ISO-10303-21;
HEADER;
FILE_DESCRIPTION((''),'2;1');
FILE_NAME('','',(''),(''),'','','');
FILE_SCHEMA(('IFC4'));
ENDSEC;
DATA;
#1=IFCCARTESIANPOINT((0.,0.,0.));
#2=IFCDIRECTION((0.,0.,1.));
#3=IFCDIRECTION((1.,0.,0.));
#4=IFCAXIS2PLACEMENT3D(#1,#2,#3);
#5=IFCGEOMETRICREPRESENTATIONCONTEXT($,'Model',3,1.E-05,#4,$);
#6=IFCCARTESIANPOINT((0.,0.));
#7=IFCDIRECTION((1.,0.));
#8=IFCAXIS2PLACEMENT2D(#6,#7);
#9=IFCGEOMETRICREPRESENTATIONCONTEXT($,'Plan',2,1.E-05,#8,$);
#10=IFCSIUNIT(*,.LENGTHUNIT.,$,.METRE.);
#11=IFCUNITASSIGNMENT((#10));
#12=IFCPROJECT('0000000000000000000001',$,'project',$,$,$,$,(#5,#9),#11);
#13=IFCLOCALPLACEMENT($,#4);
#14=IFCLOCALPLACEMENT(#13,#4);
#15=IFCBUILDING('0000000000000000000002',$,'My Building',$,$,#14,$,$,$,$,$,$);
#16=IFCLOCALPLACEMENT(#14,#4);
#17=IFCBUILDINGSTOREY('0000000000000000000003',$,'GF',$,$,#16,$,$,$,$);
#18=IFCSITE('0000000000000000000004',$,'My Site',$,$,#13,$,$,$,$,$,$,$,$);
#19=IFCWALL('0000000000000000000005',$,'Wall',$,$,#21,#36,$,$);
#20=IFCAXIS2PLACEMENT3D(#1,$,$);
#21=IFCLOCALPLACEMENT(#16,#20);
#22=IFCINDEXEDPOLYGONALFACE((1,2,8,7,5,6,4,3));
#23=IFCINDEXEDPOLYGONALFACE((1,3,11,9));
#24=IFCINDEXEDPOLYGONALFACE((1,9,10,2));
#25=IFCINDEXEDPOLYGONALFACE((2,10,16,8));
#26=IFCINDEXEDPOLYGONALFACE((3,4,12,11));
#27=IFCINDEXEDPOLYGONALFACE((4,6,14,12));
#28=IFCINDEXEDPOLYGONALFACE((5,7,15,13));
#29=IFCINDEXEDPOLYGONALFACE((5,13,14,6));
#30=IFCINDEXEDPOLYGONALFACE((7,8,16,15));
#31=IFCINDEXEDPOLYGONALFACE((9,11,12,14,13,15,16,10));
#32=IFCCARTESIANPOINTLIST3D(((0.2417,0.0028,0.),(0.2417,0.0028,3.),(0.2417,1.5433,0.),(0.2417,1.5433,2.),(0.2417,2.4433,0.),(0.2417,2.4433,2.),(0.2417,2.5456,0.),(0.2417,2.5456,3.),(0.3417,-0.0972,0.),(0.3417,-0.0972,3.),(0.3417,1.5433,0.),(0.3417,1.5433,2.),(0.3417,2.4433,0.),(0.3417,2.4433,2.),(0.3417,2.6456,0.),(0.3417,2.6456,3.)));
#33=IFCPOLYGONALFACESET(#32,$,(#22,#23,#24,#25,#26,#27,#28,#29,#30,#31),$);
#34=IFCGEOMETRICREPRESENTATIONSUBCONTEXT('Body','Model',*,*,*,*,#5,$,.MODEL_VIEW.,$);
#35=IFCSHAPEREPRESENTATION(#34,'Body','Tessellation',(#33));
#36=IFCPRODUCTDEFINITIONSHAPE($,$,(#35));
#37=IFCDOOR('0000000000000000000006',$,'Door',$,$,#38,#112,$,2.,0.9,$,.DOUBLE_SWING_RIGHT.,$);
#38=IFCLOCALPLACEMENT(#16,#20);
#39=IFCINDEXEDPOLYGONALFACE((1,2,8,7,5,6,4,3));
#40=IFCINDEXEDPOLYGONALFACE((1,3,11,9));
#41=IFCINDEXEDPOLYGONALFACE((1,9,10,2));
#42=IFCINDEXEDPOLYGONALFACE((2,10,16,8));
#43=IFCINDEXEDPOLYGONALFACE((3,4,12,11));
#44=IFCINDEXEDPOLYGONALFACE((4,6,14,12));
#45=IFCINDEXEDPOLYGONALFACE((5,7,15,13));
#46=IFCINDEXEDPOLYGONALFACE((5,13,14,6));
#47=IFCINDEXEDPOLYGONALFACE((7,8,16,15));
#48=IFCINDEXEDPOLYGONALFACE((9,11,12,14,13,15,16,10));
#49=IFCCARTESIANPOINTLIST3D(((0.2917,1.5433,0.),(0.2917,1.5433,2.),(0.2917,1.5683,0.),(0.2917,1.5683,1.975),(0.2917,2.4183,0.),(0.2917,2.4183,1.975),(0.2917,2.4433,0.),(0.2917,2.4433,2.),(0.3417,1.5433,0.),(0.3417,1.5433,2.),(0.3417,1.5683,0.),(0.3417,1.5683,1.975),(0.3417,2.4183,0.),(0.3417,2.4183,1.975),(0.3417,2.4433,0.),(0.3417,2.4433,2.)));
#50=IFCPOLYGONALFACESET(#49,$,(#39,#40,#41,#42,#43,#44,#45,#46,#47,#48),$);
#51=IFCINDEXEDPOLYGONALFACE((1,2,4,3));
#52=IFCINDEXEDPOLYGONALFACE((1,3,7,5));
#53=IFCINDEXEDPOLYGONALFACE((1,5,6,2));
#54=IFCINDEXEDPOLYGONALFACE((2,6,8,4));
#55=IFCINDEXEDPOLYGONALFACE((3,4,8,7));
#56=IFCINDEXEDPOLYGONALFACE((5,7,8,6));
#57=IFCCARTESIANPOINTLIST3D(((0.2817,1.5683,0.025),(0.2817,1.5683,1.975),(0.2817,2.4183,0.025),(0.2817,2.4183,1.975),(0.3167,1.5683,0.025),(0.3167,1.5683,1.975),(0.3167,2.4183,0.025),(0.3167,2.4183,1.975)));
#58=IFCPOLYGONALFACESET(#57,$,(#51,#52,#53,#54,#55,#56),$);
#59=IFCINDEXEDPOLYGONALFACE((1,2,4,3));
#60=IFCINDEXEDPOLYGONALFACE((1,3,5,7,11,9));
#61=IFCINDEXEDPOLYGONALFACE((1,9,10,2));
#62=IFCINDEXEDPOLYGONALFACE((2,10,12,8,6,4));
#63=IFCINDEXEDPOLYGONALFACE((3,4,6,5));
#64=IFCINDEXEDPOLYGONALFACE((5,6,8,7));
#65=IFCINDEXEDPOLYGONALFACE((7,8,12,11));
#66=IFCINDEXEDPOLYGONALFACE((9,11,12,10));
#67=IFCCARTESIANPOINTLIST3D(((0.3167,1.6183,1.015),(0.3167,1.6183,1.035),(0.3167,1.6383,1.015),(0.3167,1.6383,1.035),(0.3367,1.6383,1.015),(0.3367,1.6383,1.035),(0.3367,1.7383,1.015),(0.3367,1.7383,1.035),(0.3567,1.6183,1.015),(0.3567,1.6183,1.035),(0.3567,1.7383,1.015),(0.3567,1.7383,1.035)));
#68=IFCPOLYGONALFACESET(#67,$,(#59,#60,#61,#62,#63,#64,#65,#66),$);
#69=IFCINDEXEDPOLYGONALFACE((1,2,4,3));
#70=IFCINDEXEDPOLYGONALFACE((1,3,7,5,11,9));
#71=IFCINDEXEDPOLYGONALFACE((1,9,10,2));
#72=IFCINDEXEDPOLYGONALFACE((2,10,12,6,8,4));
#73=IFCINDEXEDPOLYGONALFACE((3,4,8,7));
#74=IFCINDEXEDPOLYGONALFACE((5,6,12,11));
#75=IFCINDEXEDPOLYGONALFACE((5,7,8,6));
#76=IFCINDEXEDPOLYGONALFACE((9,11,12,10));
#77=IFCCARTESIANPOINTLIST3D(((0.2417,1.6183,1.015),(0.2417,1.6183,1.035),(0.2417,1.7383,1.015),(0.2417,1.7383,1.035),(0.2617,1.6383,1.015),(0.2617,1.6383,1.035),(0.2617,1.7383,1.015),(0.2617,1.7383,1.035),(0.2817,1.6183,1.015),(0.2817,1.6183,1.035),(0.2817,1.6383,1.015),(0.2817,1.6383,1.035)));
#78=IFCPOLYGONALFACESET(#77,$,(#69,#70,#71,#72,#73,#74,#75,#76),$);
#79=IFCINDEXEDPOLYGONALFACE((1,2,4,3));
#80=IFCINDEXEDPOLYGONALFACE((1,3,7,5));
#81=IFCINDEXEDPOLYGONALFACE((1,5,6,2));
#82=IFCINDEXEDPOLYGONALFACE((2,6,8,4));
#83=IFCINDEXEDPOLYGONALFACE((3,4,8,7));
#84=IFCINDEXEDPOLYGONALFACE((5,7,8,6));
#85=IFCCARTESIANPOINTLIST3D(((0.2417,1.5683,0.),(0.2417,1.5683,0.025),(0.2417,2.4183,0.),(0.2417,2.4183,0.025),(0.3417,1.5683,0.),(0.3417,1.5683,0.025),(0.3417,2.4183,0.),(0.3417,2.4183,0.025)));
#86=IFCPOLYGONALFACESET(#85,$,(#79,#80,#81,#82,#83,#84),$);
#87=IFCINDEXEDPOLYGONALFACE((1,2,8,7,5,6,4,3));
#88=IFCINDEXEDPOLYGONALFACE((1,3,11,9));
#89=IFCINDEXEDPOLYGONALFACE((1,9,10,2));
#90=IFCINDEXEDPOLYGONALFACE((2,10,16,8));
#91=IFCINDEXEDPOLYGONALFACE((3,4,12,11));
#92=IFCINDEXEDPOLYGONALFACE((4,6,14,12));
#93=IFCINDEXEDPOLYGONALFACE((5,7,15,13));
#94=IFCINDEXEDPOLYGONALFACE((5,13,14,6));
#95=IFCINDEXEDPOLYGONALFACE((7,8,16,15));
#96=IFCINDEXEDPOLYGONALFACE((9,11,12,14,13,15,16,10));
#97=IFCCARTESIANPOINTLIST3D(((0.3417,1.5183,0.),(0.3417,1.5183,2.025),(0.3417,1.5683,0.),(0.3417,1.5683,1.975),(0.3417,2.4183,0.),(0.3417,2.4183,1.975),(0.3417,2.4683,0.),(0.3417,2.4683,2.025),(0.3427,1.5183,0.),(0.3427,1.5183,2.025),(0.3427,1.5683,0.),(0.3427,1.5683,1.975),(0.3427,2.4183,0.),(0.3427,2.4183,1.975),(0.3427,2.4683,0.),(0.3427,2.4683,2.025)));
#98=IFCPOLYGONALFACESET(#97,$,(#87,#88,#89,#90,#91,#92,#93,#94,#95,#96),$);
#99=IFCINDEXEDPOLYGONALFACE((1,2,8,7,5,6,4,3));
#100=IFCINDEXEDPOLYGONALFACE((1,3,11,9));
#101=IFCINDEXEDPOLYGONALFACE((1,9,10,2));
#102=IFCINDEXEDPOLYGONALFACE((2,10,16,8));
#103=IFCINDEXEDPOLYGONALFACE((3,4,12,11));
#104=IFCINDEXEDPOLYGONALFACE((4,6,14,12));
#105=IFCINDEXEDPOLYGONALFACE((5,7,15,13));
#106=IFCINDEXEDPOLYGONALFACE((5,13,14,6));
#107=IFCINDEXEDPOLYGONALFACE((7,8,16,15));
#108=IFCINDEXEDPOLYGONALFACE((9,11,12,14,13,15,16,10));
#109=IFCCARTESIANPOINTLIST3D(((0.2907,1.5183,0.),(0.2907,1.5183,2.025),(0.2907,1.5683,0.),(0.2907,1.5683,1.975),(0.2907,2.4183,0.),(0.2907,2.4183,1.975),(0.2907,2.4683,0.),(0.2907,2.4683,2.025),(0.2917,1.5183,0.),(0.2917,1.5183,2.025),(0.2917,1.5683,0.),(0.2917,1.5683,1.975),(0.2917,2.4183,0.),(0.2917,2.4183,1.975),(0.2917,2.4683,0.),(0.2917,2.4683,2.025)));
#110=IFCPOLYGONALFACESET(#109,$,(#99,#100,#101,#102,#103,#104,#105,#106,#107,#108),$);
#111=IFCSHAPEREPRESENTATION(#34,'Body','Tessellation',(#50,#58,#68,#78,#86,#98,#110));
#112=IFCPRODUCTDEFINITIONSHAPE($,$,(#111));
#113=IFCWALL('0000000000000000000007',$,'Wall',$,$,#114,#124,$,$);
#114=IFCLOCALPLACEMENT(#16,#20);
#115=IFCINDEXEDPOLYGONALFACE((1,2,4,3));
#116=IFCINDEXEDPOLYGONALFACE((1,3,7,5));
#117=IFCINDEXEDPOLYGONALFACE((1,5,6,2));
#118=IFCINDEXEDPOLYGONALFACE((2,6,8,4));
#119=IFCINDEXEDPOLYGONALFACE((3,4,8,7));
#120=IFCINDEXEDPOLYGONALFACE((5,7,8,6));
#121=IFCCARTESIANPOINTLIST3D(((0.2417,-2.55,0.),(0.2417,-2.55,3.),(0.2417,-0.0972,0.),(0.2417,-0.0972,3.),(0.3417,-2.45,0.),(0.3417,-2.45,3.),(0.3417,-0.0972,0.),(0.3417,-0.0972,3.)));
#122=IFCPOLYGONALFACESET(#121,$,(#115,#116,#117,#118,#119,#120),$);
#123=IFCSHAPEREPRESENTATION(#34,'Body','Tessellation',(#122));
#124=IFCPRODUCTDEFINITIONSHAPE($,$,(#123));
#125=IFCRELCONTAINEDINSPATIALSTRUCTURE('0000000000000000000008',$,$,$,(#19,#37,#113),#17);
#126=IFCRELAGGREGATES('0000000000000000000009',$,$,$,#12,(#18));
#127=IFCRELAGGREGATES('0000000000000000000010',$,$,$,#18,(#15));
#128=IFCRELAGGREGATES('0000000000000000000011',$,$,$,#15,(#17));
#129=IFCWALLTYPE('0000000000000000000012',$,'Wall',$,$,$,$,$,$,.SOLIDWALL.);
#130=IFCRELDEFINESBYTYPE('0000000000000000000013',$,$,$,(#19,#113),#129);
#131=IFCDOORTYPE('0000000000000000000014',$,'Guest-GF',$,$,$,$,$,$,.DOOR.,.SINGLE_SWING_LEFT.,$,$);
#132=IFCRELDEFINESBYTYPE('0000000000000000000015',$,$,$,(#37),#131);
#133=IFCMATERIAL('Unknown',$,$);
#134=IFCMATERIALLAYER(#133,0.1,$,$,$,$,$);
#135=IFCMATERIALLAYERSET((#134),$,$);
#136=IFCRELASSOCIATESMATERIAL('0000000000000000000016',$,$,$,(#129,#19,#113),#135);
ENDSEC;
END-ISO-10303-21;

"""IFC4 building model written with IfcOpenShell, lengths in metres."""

from ifc_helpers import new_model, entity, si_unit, frame, origin_with_axes, origin_2d_with_axis, place, context, subcontext, project, spatial, line, indexed_curve, outline, extrude, shape, source, transform, mapped, material, layer, layer_set, layer_usage, type_object, type_shapes, element, fill, save


model = new_model("IFC4")

# Units and contexts
model_context = context("Model", 3, precision=1e-05, world=origin_with_axes())
plan_context = context("Plan", 2, precision=1e-05, world=origin_2d_with_axis())
body_context_1 = subcontext(model_context, "Body", "Model", "MODEL_VIEW")
body_context_2 = subcontext(plan_context, "Body", "Plan", "PLAN_VIEW")
ifc_project = project(units=[si_unit("LENGTHUNIT", "METRE")], contexts=[model_context, plan_context])

# Site, building, storey
site_placement = place(None, origin_with_axes())
site = spatial("IfcSite", under=ifc_project, at=site_placement, Name="My Site")
building_placement = place(site_placement, origin_with_axes())
building = spatial("IfcBuilding", under=site, at=building_placement, Name="My Building")
storey_placement = place(building_placement, origin_with_axes())
storey = spatial("IfcBuildingStorey", under=building, at=storey_placement, Name="GF")

# Shared definitions
ifc_material_1 = material(Name="Unknown")

# Shared definitions
ifc_layer_1 = layer(ifc_material_1, 0.1)
ifc_layer_set_1 = layer_set([ifc_layer_1])
wall_type = type_object("IfcWallType", Name="Wall", PredefinedType="SOLIDWALL", material=ifc_layer_set_1)

# Wall, opening, door
ifc_layer_usage_1 = layer_usage(ifc_layer_set_1, "AXIS2", "POSITIVE", 0.0)
wall_1_placement = place(storey_placement, frame((0.3417, -0.0972, 0.0), z_axis=(0.0, 0.0, 1.0), x_axis=(0.0, 1.0, 0.0)))
wall_1 = element("IfcWall", 1, at=wall_1_placement, inside=storey, type_object=wall_type, material=ifc_layer_usage_1, Name="Wall", context=body_context_1, shape_type="SweptSolid", body=[
    extrude(outline(indexed_curve([(0.0, 0.0), (0.1, 0.1), (2.6428, 0.1), (2.7428, 0.0)], segments=[line(1, 2, 3, 4, 1)])), origin_with_axes(), (0.0, 0.0, 1.0), 3.0),
])
shared_shape_1 = source(origin_with_axes(), body_context_1, "Body", "SweptSolid", [
    extrude(outline(indexed_curve([(0.0, 0.0), (0.9, 0.0), (0.9, 2.0), (0.0, 2.0)], segments=[line(1, 2, 3, 4, 1)])), frame((0.0, -0.6, 0.0), z_axis=(0.0, -1.0, 0.0), x_axis=(1.0, 0.0, 0.0)), (0.0, 0.0, -1.0), 1.2),
])
opening_1_placement = place(wall_1_placement, frame((1.6405, 0.0, 0.0), z_axis=(0.0, 0.0, 1.0), x_axis=(1.0, 0.0, 0.0)))
opening_1 = element("IfcOpeningElement", 2, at=opening_1_placement, cuts=wall_1, PredefinedType="OPENING", context=body_context_1, shape_type="MappedRepresentation", body=[
    mapped(shared_shape_1, transform((0.0, 0.0, 0.0), x_axis=(1.0, 0.0, 0.0), y_axis=(0.0, 1.0, 0.0), z_axis=(0.0, 0.0, 1.0), scale=1.0)),
])
door_type_1 = type_object("IfcDoorType", Name="Guest-GF", OperationType="SINGLE_SWING_LEFT", PredefinedType="DOOR")
shared_shape_2 = source(origin_with_axes(), body_context_1, "Body", "SweptSolid", [
    extrude(outline(indexed_curve([(0.0, 0.0), (0.0, 2.0), (0.9, 2.0), (0.9, 0.0), (0.875, 0.0), (0.875, 1.975), (0.025, 1.975), (0.025, 0.0)], segments=[line(1, 2, 3, 4, 5, 6, 7, 8, 1)])), frame((0.0, 0.0, 0.0), z_axis=(0.0, -1.0, 0.0), x_axis=(1.0, 0.0, 0.0)), (0.0, 0.0, -1.0), 0.05),
    extrude(outline(indexed_curve([(0.0, 0.0), (0.85, 0.0), (0.85, 0.035), (0.0, 0.035)], segments=[line(1, 2, 3, 4, 1)])), frame((0.025, 0.025, 0.025), z_axis=(0.0, 0.0, 1.0), x_axis=(1.0, 0.0, 0.0)), (0.0, 0.0, 1.0), 1.95),
    extrude(outline(indexed_curve([(0.0, 0.0), (0.0, -0.04), (0.12, -0.04), (0.12, -0.02), (0.02, -0.02), (0.02, 0.0)], segments=[line(1, 2, 3, 4, 5, 6, 1)])), frame((0.075, 0.025, 1.015), z_axis=(0.0, 0.0, 1.0), x_axis=(1.0, 0.0, 0.0)), (0.0, 0.0, 1.0), 0.02),
    extrude(outline(indexed_curve([(0.0, 0.0), (0.0, 0.04), (0.12, 0.04), (0.12, 0.02), (0.02, 0.02), (0.02, 0.0)], segments=[line(1, 2, 3, 4, 5, 6, 1)])), frame((0.075, 0.06, 1.015), z_axis=(0.0, 0.0, 1.0), x_axis=(1.0, 0.0, 0.0)), (0.0, 0.0, 1.0), 0.02),
    extrude(outline(indexed_curve([(0.0, 0.0), (0.85, 0.0), (0.85, 0.1), (0.0, 0.1)], segments=[line(1, 2, 3, 4, 1)])), frame((0.025, 0.0, 0.0), z_axis=(0.0, 0.0, 1.0), x_axis=(1.0, 0.0, 0.0)), (0.0, 0.0, 1.0), 0.025),
    extrude(outline(indexed_curve([(0.0, 0.0), (0.0, 2.025), (0.95, 2.025), (0.95, 0.0), (0.9, 0.0), (0.9, 1.975), (0.05, 1.975), (0.05, 0.0)], segments=[line(1, 2, 3, 4, 5, 6, 7, 8, 1)])), frame((-0.025, -0.001, 0.0), z_axis=(0.0, -1.0, 0.0), x_axis=(1.0, 0.0, 0.0)), (0.0, 0.0, -1.0), 0.001),
    extrude(outline(indexed_curve([(0.0, 0.0), (0.0, 2.025), (0.95, 2.025), (0.95, 0.0), (0.9, 0.0), (0.9, 1.975), (0.05, 1.975), (0.05, 0.0)], segments=[line(1, 2, 3, 4, 5, 6, 7, 8, 1)])), frame((-0.025, 0.05, 0.0), z_axis=(0.0, -1.0, 0.0), x_axis=(1.0, 0.0, 0.0)), (0.0, 0.0, -1.0), 0.001),
])
shared_shape_3 = source(origin_with_axes(), body_context_2, "Body", "Curve2D", [
    entity("IfcIndexedPolyCurve", entity("IfcCartesianPointList2D", [[0.0, 0.0], [0.025, 0.0], [0.025, 0.05], [0.0, 0.05]]), [entity("IfcLineIndex", [1, 2, 3, 4, 1])]),
    entity("IfcIndexedPolyCurve", entity("IfcCartesianPointList2D", [[0.9, 0.0], [0.875, 0.0], [0.875, 0.05], [0.9, 0.05]]), [entity("IfcLineIndex", [1, 2, 3, 4, 1])]),
    entity("IfcIndexedPolyCurve", entity("IfcCartesianPointList2D", [[0.875, 0.05], [0.875, -0.8], [0.84, -0.8]])),
    entity("IfcTrimmedCurve", entity("IfcEllipse", entity("IfcAxis2Placement2D", entity("IfcCartesianPoint", [0.84, 0.05]), entity("IfcDirection", [1.0, 0.0])), 0.815, 0.85), [entity("IfcCartesianPoint", [0.84, 0.9])], [entity("IfcCartesianPoint", [0.84, -0.8])], True, "CARTESIAN"),
    entity("IfcIndexedPolyCurve", entity("IfcCartesianPointList2D", [[0.875, 0.05], [0.84, 0.05], [0.84, 0.9], [0.875, 0.9]]), [entity("IfcLineIndex", [1, 2, 3, 4, 1])]),
])
type_shapes(door_type_1, [shared_shape_2, shared_shape_3])
door_1_placement = place(opening_1_placement, frame((0.0, 0.0, 0.0), z_axis=(0.0, 0.0, 1.0), x_axis=(1.0, 0.0, 0.0)))
door_1 = element("IfcDoor", 3, at=door_1_placement, inside=storey, type_object=door_type_1, Name="Door", OperationType="DOUBLE_SWING_RIGHT", OverallHeight=2.0, OverallWidth=0.9, shapes=[
    shape(body_context_1, "Body", "MappedRepresentation", [mapped(shared_shape_2, transform((0.0, 0.0, 0.0), x_axis=(1.0, 0.0, 0.0), y_axis=(0.0, 1.0, 0.0), z_axis=(0.0, 0.0, 1.0), scale=1.0))]),
    shape(body_context_2, "Body", "MappedRepresentation", [mapped(shared_shape_3, transform((0.0, 0.0, 0.0), x_axis=(1.0, 0.0, 0.0), y_axis=(0.0, 1.0, 0.0), z_axis=(0.0, 0.0, 1.0), scale=1.0))]),
])
fill(opening_1, door_1)

# Wall
ifc_layer_usage_2 = layer_usage(ifc_layer_set_1, "AXIS2", "POSITIVE", 0.0)
wall_2_placement = place(storey_placement, frame((0.3417, -2.45, 0.0), z_axis=(0.0, 0.0, 1.0), x_axis=(0.0, 1.0, 0.0)))
element("IfcWall", 4, at=wall_2_placement, inside=storey, type_object=wall_type, material=ifc_layer_usage_2, Name="Wall", context=body_context_1, shape_type="SweptSolid", body=[
    extrude(outline(indexed_curve([(0.0, 0.0), (-0.1, 0.1), (2.3528, 0.1), (2.3528, 0.0)], segments=[line(1, 2, 3, 4, 1)])), origin_with_axes(), (0.0, 0.0, 1.0), 3.0),
])

save(model, "model.ifc")
